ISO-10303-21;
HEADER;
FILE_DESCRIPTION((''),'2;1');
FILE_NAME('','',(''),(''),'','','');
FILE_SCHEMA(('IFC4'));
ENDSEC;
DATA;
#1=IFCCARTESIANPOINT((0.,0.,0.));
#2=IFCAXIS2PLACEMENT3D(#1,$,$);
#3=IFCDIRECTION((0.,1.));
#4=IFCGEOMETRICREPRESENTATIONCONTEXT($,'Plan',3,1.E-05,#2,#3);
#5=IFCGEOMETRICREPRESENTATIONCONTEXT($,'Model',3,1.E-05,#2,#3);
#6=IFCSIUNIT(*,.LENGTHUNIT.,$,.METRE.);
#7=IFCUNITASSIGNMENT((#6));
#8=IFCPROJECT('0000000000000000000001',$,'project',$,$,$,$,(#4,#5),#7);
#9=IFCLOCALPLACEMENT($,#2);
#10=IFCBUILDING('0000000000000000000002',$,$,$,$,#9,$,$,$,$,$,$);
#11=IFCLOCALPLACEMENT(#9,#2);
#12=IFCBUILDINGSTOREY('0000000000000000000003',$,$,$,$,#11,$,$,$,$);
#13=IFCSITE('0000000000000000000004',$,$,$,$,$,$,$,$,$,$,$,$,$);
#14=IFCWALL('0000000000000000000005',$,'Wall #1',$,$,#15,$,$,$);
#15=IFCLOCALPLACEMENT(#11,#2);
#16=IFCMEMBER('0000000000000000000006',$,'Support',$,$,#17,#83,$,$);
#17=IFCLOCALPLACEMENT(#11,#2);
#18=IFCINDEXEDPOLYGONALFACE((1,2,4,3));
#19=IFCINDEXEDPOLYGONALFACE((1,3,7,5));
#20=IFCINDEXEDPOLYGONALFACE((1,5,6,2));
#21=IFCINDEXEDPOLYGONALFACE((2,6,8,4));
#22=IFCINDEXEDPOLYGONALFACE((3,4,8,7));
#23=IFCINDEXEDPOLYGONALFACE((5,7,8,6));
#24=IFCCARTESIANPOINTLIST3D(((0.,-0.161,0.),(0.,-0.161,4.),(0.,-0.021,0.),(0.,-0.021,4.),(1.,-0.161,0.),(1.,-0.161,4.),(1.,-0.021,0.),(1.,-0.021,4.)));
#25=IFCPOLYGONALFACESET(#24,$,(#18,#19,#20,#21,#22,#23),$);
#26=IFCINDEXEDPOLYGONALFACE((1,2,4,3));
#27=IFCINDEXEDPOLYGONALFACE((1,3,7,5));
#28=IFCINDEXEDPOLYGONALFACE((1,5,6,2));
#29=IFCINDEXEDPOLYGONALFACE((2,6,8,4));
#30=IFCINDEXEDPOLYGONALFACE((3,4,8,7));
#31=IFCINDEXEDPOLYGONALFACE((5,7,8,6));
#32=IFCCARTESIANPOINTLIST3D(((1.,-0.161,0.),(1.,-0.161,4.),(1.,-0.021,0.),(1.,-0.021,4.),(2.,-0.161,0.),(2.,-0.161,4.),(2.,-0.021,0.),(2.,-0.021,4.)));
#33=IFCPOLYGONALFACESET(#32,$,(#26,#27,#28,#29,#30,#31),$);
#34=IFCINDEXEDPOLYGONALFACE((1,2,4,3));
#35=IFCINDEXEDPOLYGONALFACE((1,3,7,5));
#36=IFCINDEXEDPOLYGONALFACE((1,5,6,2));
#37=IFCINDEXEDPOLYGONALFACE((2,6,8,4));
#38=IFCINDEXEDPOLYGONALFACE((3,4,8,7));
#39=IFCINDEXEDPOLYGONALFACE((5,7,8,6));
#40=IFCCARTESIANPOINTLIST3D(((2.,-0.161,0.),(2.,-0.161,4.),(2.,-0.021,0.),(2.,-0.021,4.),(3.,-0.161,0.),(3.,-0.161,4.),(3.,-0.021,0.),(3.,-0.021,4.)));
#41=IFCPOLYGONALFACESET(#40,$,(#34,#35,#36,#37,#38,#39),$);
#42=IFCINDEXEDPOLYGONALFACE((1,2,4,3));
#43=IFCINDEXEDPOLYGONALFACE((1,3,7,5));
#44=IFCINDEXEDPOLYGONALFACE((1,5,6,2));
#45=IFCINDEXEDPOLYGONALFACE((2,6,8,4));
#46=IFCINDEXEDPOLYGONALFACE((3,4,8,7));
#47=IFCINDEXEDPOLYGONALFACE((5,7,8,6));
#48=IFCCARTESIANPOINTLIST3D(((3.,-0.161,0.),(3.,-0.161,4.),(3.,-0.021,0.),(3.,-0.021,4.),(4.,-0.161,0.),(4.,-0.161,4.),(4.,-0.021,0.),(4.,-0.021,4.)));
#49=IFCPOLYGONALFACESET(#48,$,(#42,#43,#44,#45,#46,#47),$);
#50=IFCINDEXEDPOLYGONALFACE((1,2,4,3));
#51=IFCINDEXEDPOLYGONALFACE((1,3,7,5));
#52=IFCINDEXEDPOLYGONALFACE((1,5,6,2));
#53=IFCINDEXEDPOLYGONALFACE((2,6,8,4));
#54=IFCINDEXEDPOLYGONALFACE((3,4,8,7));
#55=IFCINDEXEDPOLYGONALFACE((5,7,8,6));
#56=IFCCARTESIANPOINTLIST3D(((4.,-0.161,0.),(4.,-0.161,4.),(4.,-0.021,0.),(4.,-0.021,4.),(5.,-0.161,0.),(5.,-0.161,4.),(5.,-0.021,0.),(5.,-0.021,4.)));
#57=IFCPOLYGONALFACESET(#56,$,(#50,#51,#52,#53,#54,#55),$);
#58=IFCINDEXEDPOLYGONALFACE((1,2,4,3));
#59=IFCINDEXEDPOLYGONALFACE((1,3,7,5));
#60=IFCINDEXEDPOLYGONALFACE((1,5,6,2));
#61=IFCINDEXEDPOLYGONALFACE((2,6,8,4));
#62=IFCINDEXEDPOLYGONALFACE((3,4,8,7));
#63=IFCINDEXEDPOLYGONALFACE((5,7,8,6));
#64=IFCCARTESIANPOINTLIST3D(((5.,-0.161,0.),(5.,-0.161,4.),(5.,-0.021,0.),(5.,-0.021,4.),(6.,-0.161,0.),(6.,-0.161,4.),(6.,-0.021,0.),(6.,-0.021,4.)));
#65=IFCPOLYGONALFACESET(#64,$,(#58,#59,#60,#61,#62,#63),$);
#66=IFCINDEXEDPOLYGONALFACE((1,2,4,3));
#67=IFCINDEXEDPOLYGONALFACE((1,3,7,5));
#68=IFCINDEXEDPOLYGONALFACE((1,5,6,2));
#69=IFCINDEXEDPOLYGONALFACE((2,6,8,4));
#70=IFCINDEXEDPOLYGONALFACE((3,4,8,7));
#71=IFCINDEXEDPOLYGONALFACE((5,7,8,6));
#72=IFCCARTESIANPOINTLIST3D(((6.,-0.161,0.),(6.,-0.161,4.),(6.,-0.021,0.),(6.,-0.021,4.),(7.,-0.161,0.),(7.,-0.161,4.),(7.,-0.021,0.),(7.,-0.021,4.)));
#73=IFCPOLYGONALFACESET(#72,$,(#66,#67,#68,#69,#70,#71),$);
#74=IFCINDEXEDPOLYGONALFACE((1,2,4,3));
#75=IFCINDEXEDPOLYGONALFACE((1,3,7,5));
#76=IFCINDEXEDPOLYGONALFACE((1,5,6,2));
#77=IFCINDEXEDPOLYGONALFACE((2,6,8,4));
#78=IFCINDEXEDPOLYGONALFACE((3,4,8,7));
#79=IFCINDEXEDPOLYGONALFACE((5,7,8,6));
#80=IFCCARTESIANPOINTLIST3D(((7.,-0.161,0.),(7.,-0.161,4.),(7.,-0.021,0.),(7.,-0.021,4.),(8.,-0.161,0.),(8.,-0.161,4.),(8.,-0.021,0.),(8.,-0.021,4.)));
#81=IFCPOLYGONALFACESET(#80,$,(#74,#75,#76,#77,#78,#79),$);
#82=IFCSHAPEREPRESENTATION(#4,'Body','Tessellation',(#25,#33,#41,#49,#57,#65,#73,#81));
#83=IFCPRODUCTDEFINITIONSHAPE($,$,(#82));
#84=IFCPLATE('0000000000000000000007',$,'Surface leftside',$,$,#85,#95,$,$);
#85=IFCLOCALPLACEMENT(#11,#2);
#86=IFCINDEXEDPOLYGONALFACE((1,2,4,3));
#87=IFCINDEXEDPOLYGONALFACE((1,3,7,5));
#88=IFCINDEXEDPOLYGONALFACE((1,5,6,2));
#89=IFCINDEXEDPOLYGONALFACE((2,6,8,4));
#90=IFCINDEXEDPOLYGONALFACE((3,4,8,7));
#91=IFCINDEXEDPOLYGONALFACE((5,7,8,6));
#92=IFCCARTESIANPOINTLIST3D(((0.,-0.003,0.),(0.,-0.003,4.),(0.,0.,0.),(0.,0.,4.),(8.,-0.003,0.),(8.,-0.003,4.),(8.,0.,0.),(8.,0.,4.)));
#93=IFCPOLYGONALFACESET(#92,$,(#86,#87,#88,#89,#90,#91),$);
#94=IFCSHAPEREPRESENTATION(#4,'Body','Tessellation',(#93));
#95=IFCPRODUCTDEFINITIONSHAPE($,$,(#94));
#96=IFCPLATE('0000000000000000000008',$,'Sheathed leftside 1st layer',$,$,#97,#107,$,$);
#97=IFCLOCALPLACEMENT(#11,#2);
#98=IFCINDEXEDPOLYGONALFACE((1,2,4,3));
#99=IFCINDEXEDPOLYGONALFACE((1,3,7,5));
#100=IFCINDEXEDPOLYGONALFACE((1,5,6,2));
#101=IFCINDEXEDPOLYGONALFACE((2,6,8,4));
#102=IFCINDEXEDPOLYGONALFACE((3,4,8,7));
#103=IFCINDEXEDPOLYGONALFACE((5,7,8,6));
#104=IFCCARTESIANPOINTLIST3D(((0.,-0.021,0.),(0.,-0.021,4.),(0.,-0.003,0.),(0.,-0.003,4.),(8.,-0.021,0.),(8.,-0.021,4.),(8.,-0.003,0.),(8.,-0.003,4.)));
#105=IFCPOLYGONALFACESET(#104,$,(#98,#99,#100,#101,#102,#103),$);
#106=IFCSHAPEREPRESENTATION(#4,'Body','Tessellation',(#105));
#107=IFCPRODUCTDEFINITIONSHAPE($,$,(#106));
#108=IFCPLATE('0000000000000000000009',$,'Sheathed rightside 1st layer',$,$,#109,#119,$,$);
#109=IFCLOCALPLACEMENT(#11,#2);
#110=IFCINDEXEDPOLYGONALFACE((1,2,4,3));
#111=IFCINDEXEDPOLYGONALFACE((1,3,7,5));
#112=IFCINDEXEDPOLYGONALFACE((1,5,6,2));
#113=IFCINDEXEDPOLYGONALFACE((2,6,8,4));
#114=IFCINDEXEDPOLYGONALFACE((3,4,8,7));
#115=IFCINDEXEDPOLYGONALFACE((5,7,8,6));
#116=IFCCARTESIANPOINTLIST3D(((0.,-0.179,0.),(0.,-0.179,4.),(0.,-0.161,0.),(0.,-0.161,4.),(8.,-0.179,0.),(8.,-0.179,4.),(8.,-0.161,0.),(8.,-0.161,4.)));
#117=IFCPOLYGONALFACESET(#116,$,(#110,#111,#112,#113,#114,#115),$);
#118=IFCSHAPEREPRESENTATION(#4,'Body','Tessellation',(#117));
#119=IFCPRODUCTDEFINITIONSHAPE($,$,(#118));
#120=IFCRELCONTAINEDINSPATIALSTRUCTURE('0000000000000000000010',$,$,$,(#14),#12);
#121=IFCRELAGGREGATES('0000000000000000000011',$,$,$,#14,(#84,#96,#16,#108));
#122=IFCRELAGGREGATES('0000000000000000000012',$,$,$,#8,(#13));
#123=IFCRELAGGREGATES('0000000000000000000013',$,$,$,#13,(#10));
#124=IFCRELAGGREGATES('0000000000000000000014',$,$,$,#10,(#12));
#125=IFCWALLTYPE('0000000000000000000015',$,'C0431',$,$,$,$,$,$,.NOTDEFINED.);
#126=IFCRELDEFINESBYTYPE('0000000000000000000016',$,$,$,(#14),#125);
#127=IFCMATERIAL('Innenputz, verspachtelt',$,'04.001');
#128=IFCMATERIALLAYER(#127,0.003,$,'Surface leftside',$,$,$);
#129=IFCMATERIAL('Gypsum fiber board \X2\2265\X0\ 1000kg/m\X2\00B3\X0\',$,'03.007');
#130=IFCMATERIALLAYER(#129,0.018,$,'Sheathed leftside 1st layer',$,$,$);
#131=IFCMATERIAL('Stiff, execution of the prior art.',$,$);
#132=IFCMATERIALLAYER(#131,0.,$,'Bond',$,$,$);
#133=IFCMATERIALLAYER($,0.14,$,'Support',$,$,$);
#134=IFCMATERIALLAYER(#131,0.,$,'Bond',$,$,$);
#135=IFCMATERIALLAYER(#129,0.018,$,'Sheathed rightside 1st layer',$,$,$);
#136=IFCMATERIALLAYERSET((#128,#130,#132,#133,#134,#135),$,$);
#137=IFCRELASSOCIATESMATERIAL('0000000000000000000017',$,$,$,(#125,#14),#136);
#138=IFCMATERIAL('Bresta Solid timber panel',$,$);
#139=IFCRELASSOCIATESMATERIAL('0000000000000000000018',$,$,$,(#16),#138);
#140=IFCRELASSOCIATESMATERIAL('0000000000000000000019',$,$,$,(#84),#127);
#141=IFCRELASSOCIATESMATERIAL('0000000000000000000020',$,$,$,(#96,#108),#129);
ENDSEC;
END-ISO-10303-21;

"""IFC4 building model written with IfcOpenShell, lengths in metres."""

from ifc_helpers import new_model, si_unit, direction, frame, frame_2d, origin, origin_with_axes, place, context, project, spatial, rectangle, extrude, material, layer, layer_set, type_object, element, aggregate, save


model = new_model("IFC4")

# Units and contexts
plan_context = context("Plan", 3, precision=1e-05, world=origin(), true_north=direction((0.0, 1.0)))
model_context = context("Model", 3, precision=1e-05, world=origin(), true_north=direction((0.0, 1.0)))
ifc_project = project(units=[si_unit("LENGTHUNIT", "METRE")], contexts=[plan_context, model_context])

# Site, building, storey
site = spatial("IfcSite", under=ifc_project)
building_placement = place(None, origin())
building = spatial("IfcBuilding", under=site, at=building_placement)
storey_placement = place(building_placement, origin())
storey = spatial("IfcBuildingStorey", under=building, at=storey_placement)

# Wall, member, plates
ifc_material_1 = material(Name="Innenputz, verspachtelt", Category="04.001")
ifc_layer_1 = layer(ifc_material_1, 0.003, Name="Surface leftside")
ifc_material_2 = material(Name="Gypsum fiber board ≥ 1000kg/m³", Category="03.007")
ifc_layer_2 = layer(ifc_material_2, 0.018, Name="Sheathed leftside 1st layer")
ifc_material_3 = material(Name="Stiff, execution of the prior art.")
ifc_layer_3 = layer(ifc_material_3, 0.0, Name="Bond")
ifc_layer_4 = layer(None, 0.14, Name="Support")
ifc_layer_5 = layer(ifc_material_3, 0.0, Name="Bond")
ifc_layer_6 = layer(ifc_material_2, 0.018, Name="Sheathed rightside 1st layer")
ifc_layer_set = layer_set([ifc_layer_1, ifc_layer_2, ifc_layer_3, ifc_layer_4, ifc_layer_5, ifc_layer_6])
wall_type = type_object("IfcWallType", Name="C0431", PredefinedType="NOTDEFINED", material=ifc_layer_set)
wall_placement = place(None, frame((0.0, 0.0, 0.0), z_axis=(0.0, -1.0, 0.0), x_axis=(1.0, 0.0, 0.0)))
wall = element("IfcWall", 1, at=wall_placement, inside=storey, type_object=wall_type, material=ifc_layer_set, Name="Wall #1")
ifc_material_4 = material(Name="Bresta Solid timber panel")
member_placement = place(wall_placement, origin())
member = element("IfcMember", 2, at=member_placement, material=ifc_material_4, Name="Support", context=plan_context, shape_type="SweptSolid", body=[
    extrude(rectangle(XDim=1.0, YDim=0.14, at=frame_2d((0.5, 0.07), x_axis=(1.0, 0.0))), frame((0.0, 4.0, 0.021), z_axis=(0.0, -1.0, 0.0), x_axis=(1.0, 0.0, 0.0)), (0.0, 0.0, 1.0), 4.0),
    extrude(rectangle(XDim=1.0, YDim=0.14, at=frame_2d((0.5, 0.07), x_axis=(1.0, 0.0))), frame((1.0, 4.0, 0.021), z_axis=(0.0, -1.0, 0.0), x_axis=(1.0, 0.0, 0.0)), (0.0, 0.0, 1.0), 4.0),
    extrude(rectangle(XDim=1.0, YDim=0.14, at=frame_2d((0.5, 0.07), x_axis=(1.0, 0.0))), frame((2.0, 4.0, 0.021), z_axis=(0.0, -1.0, 0.0), x_axis=(1.0, 0.0, 0.0)), (0.0, 0.0, 1.0), 4.0),
    extrude(rectangle(XDim=1.0, YDim=0.14, at=frame_2d((0.5, 0.07), x_axis=(1.0, 0.0))), frame((3.0, 4.0, 0.021), z_axis=(0.0, -1.0, 0.0), x_axis=(1.0, 0.0, 0.0)), (0.0, 0.0, 1.0), 4.0),
    extrude(rectangle(XDim=1.0, YDim=0.14, at=frame_2d((0.5, 0.07), x_axis=(1.0, 0.0))), frame((4.0, 4.0, 0.021), z_axis=(0.0, -1.0, 0.0), x_axis=(1.0, 0.0, 0.0)), (0.0, 0.0, 1.0), 4.0),
    extrude(rectangle(XDim=1.0, YDim=0.14, at=frame_2d((0.5, 0.07), x_axis=(1.0, 0.0))), frame((5.0, 4.0, 0.021), z_axis=(0.0, -1.0, 0.0), x_axis=(1.0, 0.0, 0.0)), (0.0, 0.0, 1.0), 4.0),
    extrude(rectangle(XDim=1.0, YDim=0.14, at=frame_2d((0.5, 0.07), x_axis=(1.0, 0.0))), frame((6.0, 4.0, 0.021), z_axis=(0.0, -1.0, 0.0), x_axis=(1.0, 0.0, 0.0)), (0.0, 0.0, 1.0), 4.0),
    extrude(rectangle(XDim=1.0, YDim=0.14, at=frame_2d((0.5, 0.07), x_axis=(1.0, 0.0))), frame((7.0, 4.0, 0.021), z_axis=(0.0, -1.0, 0.0), x_axis=(1.0, 0.0, 0.0)), (0.0, 0.0, 1.0), 4.0),
])
plate_1_placement = place(wall_placement, origin())
plate_1 = element("IfcPlate", 3, at=plate_1_placement, material=ifc_material_1, Name="Surface leftside", context=plan_context, shape_type="SweptSolid", body=[
    extrude(rectangle(XDim=8.0, YDim=4.0, at=frame_2d((4.0, 2.0), x_axis=(1.0, 0.0))), origin_with_axes(), (0.0, 0.0, 1.0), 0.003),
])
plate_2_placement = place(wall_placement, origin())
plate_2 = element("IfcPlate", 4, at=plate_2_placement, material=ifc_material_2, Name="Sheathed leftside 1st layer", context=plan_context, shape_type="SweptSolid", body=[
    extrude(rectangle(XDim=8.0, YDim=4.0, at=frame_2d((4.0, 2.0), x_axis=(1.0, 0.0))), frame((0.0, 0.0, 0.003), z_axis=(0.0, 0.0, 1.0), x_axis=(1.0, 0.0, 0.0)), (0.0, 0.0, 1.0), 0.018),
])
plate_3_placement = place(wall_placement, origin())
plate_3 = element("IfcPlate", 5, at=plate_3_placement, material=ifc_material_2, Name="Sheathed rightside 1st layer", context=plan_context, shape_type="SweptSolid", body=[
    extrude(rectangle(XDim=8.0, YDim=4.0, at=frame_2d((4.0, 2.0), x_axis=(1.0, 0.0))), frame((0.0, 0.0, 0.161), z_axis=(0.0, 0.0, 1.0), x_axis=(1.0, 0.0, 0.0)), (0.0, 0.0, 1.0), 0.018),
])
aggregate(wall, [plate_1, plate_2, member, plate_3])

save(model, "model.ifc")
